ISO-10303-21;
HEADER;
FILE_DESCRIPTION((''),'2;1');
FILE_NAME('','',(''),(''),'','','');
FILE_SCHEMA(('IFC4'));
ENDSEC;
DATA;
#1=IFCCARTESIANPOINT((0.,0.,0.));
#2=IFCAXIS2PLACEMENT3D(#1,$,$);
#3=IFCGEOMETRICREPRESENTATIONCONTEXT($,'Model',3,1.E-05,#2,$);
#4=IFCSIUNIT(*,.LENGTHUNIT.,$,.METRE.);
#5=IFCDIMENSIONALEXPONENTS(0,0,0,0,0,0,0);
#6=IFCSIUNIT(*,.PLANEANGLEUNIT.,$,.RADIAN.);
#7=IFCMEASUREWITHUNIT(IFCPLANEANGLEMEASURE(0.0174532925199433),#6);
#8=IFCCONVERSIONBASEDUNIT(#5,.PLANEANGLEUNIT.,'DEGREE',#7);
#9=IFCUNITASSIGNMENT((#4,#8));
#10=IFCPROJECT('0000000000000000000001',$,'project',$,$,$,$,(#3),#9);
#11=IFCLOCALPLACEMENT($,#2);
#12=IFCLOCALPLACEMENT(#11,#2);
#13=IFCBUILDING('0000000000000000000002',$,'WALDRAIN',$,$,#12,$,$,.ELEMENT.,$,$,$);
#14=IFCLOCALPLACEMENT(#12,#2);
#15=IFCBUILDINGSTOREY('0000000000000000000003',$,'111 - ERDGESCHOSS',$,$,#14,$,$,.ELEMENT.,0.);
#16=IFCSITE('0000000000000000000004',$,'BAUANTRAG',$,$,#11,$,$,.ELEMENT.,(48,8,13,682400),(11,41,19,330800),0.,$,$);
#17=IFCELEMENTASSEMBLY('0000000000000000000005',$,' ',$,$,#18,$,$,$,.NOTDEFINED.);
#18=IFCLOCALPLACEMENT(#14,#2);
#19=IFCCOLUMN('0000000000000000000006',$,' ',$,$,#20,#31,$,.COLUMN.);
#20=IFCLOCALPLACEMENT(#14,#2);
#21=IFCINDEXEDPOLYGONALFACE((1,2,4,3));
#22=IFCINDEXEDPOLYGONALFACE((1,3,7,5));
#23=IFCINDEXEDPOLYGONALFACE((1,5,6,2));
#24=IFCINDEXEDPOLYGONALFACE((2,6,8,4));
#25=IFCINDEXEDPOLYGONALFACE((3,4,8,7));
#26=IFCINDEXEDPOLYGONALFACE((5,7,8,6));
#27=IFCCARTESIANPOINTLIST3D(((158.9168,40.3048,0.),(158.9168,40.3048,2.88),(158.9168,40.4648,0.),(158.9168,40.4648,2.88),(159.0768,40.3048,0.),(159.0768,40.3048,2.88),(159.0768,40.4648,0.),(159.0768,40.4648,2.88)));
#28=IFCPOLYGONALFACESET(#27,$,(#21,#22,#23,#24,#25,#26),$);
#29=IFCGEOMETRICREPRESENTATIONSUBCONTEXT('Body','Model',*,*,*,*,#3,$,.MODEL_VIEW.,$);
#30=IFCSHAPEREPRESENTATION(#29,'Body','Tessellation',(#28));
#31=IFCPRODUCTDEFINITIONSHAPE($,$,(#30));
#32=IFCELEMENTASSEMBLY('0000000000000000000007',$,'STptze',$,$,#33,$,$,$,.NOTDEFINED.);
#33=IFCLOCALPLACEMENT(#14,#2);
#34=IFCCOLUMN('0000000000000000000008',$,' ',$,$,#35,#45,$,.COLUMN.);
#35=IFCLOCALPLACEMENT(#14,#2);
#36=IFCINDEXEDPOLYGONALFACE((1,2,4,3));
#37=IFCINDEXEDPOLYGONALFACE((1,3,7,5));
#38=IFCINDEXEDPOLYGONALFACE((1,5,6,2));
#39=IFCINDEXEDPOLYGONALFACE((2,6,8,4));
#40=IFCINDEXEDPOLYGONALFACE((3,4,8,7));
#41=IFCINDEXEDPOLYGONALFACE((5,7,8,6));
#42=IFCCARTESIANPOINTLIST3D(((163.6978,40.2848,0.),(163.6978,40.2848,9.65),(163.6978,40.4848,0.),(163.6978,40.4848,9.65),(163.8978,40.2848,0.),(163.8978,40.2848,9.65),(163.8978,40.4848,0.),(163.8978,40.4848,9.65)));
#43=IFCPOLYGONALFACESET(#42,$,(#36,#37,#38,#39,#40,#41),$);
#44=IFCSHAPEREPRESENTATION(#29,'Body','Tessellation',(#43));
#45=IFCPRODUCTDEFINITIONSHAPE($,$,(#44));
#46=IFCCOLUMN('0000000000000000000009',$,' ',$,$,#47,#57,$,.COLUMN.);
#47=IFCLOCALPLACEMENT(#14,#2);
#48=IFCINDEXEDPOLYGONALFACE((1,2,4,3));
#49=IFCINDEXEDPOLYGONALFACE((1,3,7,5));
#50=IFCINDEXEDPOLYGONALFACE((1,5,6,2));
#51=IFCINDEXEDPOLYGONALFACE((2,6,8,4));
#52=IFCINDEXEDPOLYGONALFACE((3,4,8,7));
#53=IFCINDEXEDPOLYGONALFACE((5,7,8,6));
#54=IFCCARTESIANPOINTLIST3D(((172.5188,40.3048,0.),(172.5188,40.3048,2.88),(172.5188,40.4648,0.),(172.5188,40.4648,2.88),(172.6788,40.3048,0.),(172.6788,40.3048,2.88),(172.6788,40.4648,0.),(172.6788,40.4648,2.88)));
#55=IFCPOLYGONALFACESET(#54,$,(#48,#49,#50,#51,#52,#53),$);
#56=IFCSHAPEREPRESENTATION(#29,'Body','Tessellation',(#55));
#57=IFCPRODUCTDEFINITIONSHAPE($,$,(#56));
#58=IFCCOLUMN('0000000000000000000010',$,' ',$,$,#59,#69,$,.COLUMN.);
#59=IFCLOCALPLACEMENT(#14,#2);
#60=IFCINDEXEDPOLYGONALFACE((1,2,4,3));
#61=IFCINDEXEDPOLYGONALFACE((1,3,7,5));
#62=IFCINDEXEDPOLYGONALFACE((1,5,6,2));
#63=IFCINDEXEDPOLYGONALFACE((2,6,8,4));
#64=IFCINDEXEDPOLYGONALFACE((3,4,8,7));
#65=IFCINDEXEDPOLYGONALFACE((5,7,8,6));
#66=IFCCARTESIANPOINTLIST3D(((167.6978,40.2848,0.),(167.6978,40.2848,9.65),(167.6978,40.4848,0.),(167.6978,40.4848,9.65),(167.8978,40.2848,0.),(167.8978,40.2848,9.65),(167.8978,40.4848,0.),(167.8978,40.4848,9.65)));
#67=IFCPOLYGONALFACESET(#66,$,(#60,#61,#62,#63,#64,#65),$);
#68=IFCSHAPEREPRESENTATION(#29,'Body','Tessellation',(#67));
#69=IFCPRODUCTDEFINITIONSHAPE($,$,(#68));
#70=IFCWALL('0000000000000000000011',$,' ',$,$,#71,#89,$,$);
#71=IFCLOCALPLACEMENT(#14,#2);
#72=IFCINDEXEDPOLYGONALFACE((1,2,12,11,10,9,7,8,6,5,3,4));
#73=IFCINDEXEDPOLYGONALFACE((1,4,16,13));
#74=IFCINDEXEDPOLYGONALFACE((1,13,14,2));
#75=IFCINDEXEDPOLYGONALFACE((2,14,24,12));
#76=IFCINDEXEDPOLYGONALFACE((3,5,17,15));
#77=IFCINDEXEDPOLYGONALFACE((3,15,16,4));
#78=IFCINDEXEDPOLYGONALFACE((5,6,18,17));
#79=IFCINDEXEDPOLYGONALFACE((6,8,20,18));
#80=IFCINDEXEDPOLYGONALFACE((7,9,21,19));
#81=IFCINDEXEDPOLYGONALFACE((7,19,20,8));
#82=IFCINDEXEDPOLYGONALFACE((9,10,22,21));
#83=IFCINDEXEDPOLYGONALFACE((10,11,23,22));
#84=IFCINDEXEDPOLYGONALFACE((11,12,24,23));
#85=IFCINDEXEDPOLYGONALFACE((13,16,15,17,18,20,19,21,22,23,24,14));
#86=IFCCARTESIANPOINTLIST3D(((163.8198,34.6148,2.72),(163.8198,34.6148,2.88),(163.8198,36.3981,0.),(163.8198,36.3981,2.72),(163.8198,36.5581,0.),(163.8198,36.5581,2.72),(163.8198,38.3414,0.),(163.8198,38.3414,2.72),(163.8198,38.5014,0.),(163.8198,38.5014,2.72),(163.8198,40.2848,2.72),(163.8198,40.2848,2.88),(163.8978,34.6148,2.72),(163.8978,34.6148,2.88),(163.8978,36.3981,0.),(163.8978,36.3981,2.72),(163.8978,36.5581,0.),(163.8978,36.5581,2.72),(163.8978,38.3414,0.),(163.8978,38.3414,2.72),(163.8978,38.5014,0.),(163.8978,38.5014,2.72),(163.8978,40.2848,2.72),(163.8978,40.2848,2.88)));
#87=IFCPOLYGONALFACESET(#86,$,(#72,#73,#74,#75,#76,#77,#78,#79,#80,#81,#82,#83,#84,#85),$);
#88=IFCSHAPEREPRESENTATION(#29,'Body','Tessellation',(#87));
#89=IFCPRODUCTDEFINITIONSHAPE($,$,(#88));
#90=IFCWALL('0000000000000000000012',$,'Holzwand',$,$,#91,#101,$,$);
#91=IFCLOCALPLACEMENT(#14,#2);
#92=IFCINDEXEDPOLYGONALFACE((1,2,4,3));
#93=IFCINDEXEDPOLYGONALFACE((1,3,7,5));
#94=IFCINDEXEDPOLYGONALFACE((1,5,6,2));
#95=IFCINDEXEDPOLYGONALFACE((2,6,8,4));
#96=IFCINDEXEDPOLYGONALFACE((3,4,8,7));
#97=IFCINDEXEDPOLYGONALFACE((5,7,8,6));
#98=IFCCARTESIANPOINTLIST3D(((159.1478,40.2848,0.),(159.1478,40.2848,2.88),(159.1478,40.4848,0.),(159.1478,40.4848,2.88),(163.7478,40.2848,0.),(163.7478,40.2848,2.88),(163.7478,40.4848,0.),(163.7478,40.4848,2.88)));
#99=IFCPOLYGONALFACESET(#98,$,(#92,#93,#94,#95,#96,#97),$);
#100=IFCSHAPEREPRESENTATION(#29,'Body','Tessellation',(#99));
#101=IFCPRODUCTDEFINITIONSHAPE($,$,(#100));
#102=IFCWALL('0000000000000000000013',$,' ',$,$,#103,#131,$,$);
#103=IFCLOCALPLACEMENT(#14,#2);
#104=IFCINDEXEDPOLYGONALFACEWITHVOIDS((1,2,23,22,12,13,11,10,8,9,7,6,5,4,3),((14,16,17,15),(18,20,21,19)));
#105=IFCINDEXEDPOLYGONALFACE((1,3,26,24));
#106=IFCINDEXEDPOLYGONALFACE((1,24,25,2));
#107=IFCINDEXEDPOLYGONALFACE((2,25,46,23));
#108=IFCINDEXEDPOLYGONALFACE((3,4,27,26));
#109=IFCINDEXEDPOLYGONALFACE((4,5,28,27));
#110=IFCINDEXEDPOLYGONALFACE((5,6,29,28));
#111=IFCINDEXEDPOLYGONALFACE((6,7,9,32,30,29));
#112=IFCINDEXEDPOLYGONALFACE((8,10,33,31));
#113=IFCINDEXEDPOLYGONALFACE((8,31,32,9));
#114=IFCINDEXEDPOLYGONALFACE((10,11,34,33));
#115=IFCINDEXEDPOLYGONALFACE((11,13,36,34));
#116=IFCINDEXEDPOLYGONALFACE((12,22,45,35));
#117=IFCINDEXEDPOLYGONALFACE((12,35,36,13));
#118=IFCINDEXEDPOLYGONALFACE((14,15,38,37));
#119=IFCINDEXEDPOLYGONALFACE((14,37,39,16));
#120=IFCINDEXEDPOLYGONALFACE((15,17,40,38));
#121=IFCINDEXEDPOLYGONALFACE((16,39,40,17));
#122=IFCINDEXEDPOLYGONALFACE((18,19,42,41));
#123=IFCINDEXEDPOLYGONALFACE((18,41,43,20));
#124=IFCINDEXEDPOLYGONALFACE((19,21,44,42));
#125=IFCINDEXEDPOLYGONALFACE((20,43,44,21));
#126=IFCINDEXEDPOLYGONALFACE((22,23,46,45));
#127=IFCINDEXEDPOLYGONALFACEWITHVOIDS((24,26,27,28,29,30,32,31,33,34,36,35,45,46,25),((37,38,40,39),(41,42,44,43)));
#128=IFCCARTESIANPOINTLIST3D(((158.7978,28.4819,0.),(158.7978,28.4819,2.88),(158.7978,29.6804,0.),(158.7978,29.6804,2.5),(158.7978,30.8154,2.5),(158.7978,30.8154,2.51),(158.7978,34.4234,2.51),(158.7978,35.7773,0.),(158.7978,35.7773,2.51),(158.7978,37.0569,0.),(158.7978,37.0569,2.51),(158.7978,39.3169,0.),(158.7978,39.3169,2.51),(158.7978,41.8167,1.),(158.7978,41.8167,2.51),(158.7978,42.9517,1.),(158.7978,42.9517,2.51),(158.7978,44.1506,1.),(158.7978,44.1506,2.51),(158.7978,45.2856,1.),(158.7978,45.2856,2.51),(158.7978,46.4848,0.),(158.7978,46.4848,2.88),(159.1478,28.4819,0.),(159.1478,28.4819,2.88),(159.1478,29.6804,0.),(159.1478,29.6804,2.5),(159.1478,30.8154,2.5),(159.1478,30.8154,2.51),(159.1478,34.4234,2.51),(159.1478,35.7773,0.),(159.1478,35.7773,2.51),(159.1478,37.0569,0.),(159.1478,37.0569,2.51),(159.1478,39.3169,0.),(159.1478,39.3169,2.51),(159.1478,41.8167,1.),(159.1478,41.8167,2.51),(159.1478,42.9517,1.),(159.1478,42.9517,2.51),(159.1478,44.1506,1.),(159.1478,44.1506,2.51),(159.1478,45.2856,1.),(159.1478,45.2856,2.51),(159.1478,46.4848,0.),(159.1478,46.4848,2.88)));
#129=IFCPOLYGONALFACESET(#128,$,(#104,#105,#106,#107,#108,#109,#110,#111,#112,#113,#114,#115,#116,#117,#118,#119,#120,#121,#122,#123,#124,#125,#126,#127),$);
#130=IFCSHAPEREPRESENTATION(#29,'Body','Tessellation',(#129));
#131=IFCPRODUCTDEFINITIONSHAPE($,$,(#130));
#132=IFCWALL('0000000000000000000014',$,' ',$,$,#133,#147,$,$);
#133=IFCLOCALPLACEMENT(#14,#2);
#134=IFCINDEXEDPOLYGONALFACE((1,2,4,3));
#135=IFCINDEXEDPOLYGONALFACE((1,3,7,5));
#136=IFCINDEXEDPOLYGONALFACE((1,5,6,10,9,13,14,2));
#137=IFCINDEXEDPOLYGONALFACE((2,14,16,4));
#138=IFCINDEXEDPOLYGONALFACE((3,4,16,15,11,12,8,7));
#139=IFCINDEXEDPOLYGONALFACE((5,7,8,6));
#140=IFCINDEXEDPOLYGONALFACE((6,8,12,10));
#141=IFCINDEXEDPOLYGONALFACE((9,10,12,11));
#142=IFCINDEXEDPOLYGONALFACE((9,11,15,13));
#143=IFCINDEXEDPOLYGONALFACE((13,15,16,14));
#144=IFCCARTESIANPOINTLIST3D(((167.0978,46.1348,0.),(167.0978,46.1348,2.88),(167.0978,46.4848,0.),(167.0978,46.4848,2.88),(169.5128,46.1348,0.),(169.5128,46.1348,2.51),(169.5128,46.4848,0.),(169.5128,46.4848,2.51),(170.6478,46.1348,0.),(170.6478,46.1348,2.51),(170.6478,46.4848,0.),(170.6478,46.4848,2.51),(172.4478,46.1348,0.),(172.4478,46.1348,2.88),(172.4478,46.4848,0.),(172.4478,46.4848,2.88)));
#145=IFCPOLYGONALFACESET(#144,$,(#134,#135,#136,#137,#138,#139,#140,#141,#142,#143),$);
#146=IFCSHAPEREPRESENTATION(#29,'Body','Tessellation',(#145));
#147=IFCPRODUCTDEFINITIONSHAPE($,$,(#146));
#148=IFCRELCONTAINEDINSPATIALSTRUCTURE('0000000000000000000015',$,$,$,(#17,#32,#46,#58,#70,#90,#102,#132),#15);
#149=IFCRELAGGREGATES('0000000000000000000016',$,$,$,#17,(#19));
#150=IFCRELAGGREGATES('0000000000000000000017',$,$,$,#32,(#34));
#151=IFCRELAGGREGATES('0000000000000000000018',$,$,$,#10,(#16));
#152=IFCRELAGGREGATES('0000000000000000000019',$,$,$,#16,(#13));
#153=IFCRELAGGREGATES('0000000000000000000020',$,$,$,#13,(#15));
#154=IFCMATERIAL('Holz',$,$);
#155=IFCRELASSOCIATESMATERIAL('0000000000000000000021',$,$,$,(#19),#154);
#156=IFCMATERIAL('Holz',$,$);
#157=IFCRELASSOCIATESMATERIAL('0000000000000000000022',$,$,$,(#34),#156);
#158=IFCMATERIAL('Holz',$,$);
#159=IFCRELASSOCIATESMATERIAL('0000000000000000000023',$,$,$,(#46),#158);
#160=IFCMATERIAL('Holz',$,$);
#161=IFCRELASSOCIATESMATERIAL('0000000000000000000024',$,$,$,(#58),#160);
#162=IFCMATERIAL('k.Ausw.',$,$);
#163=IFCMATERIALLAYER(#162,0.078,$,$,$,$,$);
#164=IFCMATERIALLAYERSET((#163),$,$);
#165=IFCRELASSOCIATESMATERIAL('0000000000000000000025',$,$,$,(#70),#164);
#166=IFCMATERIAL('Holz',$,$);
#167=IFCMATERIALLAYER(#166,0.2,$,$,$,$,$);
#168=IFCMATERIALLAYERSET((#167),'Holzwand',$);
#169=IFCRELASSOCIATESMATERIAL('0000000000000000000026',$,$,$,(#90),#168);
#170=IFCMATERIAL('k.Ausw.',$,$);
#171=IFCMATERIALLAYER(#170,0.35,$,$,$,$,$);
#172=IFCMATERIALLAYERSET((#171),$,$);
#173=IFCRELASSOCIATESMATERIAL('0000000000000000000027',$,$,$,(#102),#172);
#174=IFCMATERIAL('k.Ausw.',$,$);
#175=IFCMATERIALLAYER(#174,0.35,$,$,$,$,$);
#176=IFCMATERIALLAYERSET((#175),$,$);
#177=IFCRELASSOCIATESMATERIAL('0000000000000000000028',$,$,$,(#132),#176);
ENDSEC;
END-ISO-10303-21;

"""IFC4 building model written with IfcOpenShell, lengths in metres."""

from ifc_helpers import new_model, entity, si_unit, converted_unit, frame, frame_2d, origin, origin_with_axes, place, context, subcontext, project, spatial, polyline, rectangle, outline, extrude, material, layer, layer_set, layer_usage, element, aggregate, save


model = new_model("IFC4")

# Units and contexts
model_context = context("Model", 3, precision=1e-05, world=origin())
body_context = subcontext(model_context, "Body", "Model", "MODEL_VIEW")
ifc_project = project(units=[si_unit("LENGTHUNIT", "METRE"), converted_unit("PLANEANGLEUNIT", "DEGREE", entity("IfcPlaneAngleMeasure", 0.0174532925199433), si_unit("PLANEANGLEUNIT", "RADIAN"), dimensions=[0, 0, 0, 0, 0, 0, 0])], contexts=[model_context])

# Site, building, storey
site_placement = place(None, origin())
site = spatial("IfcSite", under=ifc_project, at=site_placement, Name="BAUANTRAG", CompositionType="ELEMENT", RefLatitude=(48, 8, 13, 682400), RefLongitude=(11, 41, 19, 330800), RefElevation=0.0)
building_placement = place(site_placement, origin())
building = spatial("IfcBuilding", under=site, at=building_placement, Name="WALDRAIN", CompositionType="ELEMENT")
storey_placement = place(building_placement, origin())
storey = spatial("IfcBuildingStorey", under=building, at=storey_placement, Name="111 - ERDGESCHOSS", CompositionType="ELEMENT", Elevation=0.0)

# Element assemblies, columns
assembly_1_placement = place(storey_placement, origin())
assembly_1 = element("IfcElementAssembly", 1, at=assembly_1_placement, inside=storey, Name=" ", PredefinedType="NOTDEFINED")
ifc_material_1 = material(Name="Holz")
column_1_placement = place(assembly_1_placement, frame((158.9168, 40.3048, 0.0)))
column_1 = element("IfcColumn", 2, at=column_1_placement, material=ifc_material_1, Name=" ", PredefinedType="COLUMN", context=body_context, shape_type="SweptSolid", body=[
    extrude(rectangle(XDim=0.16, YDim=0.16, at=frame_2d((0.08, 0.08), x_axis=(1.0, 0.0))), origin_with_axes(), (0.0, 0.0, 1.0), 2.88),
])
aggregate(assembly_1, [column_1])
assembly_2_placement = place(storey_placement, origin())
assembly_2 = element("IfcElementAssembly", 3, at=assembly_2_placement, inside=storey, Name="STptze", PredefinedType="NOTDEFINED")
ifc_material_2 = material(Name="Holz")
column_2_placement = place(assembly_2_placement, frame((163.6978, 40.2848, 0.0)))
column_2 = element("IfcColumn", 4, at=column_2_placement, material=ifc_material_2, Name=" ", PredefinedType="COLUMN", context=body_context, shape_type="SweptSolid", body=[
    extrude(rectangle(XDim=0.2, YDim=0.2, at=frame_2d((0.1, 0.1), x_axis=(1.0, 0.0))), origin_with_axes(), (0.0, 0.0, 1.0), 9.65),
])
aggregate(assembly_2, [column_2])

# Columns
ifc_material_3 = material(Name="Holz")
column_3_placement = place(storey_placement, frame((172.5188, 40.3048, 0.0)))
element("IfcColumn", 5, at=column_3_placement, inside=storey, material=ifc_material_3, Name=" ", PredefinedType="COLUMN", context=body_context, shape_type="SweptSolid", body=[
    extrude(rectangle(XDim=0.16, YDim=0.16, at=frame_2d((0.08, 0.08), x_axis=(1.0, 0.0))), origin_with_axes(), (0.0, 0.0, 1.0), 2.88),
])
ifc_material_4 = material(Name="Holz")
column_4_placement = place(storey_placement, frame((167.6978, 40.2848, 0.0)))
element("IfcColumn", 6, at=column_4_placement, inside=storey, material=ifc_material_4, Name=" ", PredefinedType="COLUMN", context=body_context, shape_type="SweptSolid", body=[
    extrude(rectangle(XDim=0.2, YDim=0.2, at=frame_2d((0.1, 0.1), x_axis=(1.0, 0.0))), origin_with_axes(), (0.0, 0.0, 1.0), 9.65),
])

# Wall, openings
ifc_material_5 = material(Name="k.Ausw.")
ifc_layer_1 = layer(ifc_material_5, 0.078)
ifc_layer_set_1 = layer_set([ifc_layer_1])
ifc_layer_usage_1 = layer_usage(ifc_layer_set_1, "AXIS2", "POSITIVE", 0.0)
wall_1_placement = place(storey_placement, frame((163.8198, 40.2848, 0.0), z_axis=(0.0, 0.0, 1.0), x_axis=(0.0, -1.0, 0.0)))
wall_1 = element("IfcWall", 7, at=wall_1_placement, inside=storey, material=ifc_layer_usage_1, Name=" ", context=body_context, shape_type="SweptSolid", body=[
    extrude(rectangle(XDim=5.67, YDim=0.078, at=frame_2d((2.835, 0.039), x_axis=(1.0, 0.0))), origin_with_axes(), (0.0, 0.0, 1.0), 2.88),
])
opening_1_placement = place(wall_1_placement, frame((1.9434, 0.0, 0.0), z_axis=(0.0, 1.0, 0.0), x_axis=(0.0, 0.0, 1.0)))
element("IfcOpeningElement", 8, at=opening_1_placement, cuts=wall_1, ObjectType="Opening", context=body_context, shape_type="SweptSolid", body=[
    extrude(outline(polyline([(0.0, 1.7833), (2.72, 1.7833), (2.72, 0.0), (0.0, 0.0), (0.0, 1.7833)])), origin_with_axes(), (0.0, 0.0, 1.0), 0.078),
])
opening_2_placement = place(wall_1_placement, frame((0.0, 0.0, 0.0), z_axis=(0.0, 1.0, 0.0), x_axis=(0.0, 0.0, 1.0)))
element("IfcOpeningElement", 9, at=opening_2_placement, cuts=wall_1, ObjectType="Opening", context=body_context, shape_type="SweptSolid", body=[
    extrude(outline(polyline([(0.0, 1.7834), (2.72, 1.7834), (2.72, 0.0), (0.0, 0.0), (0.0, 1.7834)])), origin_with_axes(), (0.0, 0.0, 1.0), 0.078),
])
opening_3_placement = place(wall_1_placement, frame((3.8867, 0.0, 0.0), z_axis=(0.0, 1.0, 0.0), x_axis=(0.0, 0.0, 1.0)))
element("IfcOpeningElement", 10, at=opening_3_placement, cuts=wall_1, ObjectType="Opening", context=body_context, shape_type="SweptSolid", body=[
    extrude(outline(polyline([(0.0, 1.7833), (2.72, 1.7833), (2.72, 0.0), (0.0, 0.0), (0.0, 1.7833)])), origin_with_axes(), (0.0, 0.0, 1.0), 0.078),
])

# Wall
ifc_material_6 = material(Name="Holz")
ifc_layer_2 = layer(ifc_material_6, 0.2)
ifc_layer_set_2 = layer_set([ifc_layer_2], Name="Holzwand")
ifc_layer_usage_2 = layer_usage(ifc_layer_set_2, "AXIS2", "POSITIVE", 0.0)
wall_2_placement = place(storey_placement, frame((163.7478, 40.4848, 0.0), z_axis=(0.0, 0.0, 1.0), x_axis=(-1.0, 0.0, 0.0)))
element("IfcWall", 11, at=wall_2_placement, inside=storey, material=ifc_layer_usage_2, Name="Holzwand", context=body_context, shape_type="SweptSolid", body=[
    extrude(rectangle(XDim=4.6, YDim=0.2, at=frame_2d((2.3, 0.1), x_axis=(1.0, 0.0))), origin_with_axes(), (0.0, 0.0, 1.0), 2.88),
])

# Wall, openings
ifc_material_7 = material(Name="k.Ausw.")
ifc_layer_3 = layer(ifc_material_7, 0.35)
ifc_layer_set_3 = layer_set([ifc_layer_3])
ifc_layer_usage_3 = layer_usage(ifc_layer_set_3, "AXIS2", "POSITIVE", 0.0)
wall_3_placement = place(storey_placement, frame((158.7978, 46.4848, 0.0), z_axis=(0.0, 0.0, 1.0), x_axis=(0.0, -1.0, 0.0)))
wall_3 = element("IfcWall", 12, at=wall_3_placement, inside=storey, material=ifc_layer_usage_3, Name=" ", context=body_context, shape_type="SweptSolid", body=[
    extrude(rectangle(XDim=18.0029, YDim=0.35, at=frame_2d((9.0014, 0.175), x_axis=(1.0, 0.0))), origin_with_axes(), (0.0, 0.0, 1.0), 2.88),
])
opening_4_placement = place(wall_3_placement, frame((1.1992, 0.0, 1.0), z_axis=(0.0, 1.0, 0.0), x_axis=(0.0, 0.0, 1.0)))
element("IfcOpeningElement", 13, at=opening_4_placement, cuts=wall_3, ObjectType="Opening", context=body_context, shape_type="SweptSolid", body=[
    extrude(outline(polyline([(0.0, 1.135), (1.51, 1.135), (1.51, 0.0), (0.0, 0.0), (0.0, 1.135)])), origin_with_axes(), (0.0, 0.0, 1.0), 0.35),
])
opening_5_placement = place(wall_3_placement, frame((3.5331, 0.0, 1.0), z_axis=(0.0, 1.0, 0.0), x_axis=(0.0, 0.0, 1.0)))
element("IfcOpeningElement", 14, at=opening_5_placement, cuts=wall_3, ObjectType="Opening", context=body_context, shape_type="SweptSolid", body=[
    extrude(outline(polyline([(0.0, 1.135), (1.51, 1.135), (1.51, 0.0), (0.0, 0.0), (0.0, 1.135)])), origin_with_axes(), (0.0, 0.0, 1.0), 0.35),
])
opening_6_placement = place(wall_3_placement, frame((7.1679, 0.0, 0.0), z_axis=(0.0, 1.0, 0.0), x_axis=(0.0, 0.0, 1.0)))
element("IfcOpeningElement", 15, at=opening_6_placement, cuts=wall_3, ObjectType="Opening", context=body_context, shape_type="SweptSolid", body=[
    extrude(outline(polyline([(0.0, 2.26), (2.51, 2.26), (2.51, 0.0), (0.0, 0.0), (0.0, 2.26)])), origin_with_axes(), (0.0, 0.0, 1.0), 0.35),
])
opening_7_placement = place(wall_3_placement, frame((10.7075, 0.0, 0.0), z_axis=(0.0, 1.0, 0.0), x_axis=(0.0, 0.0, 1.0)))
element("IfcOpeningElement", 16, at=opening_7_placement, cuts=wall_3, ObjectType="Opening", context=body_context, shape_type="SweptSolid", body=[
    extrude(outline(polyline([(0.0, 1.3539), (2.51, 1.3539), (2.51, 0.0), (0.0, 0.0), (0.0, 1.3539)])), origin_with_axes(), (0.0, 0.0, 1.0), 0.35),
])
opening_8_placement = place(wall_3_placement, frame((15.6694, 0.0, 0.0), z_axis=(0.0, 1.0, 0.0), x_axis=(0.0, 0.0, 1.0)))
element("IfcOpeningElement", 17, at=opening_8_placement, cuts=wall_3, ObjectType="Opening", context=body_context, shape_type="SweptSolid", body=[
    extrude(outline(polyline([(0.0, 1.135), (2.5, 1.135), (2.5, 0.0), (0.0, 0.0), (0.0, 1.135)])), origin_with_axes(), (0.0, 0.0, 1.0), 0.35),
])
opening_9_placement = place(wall_3_placement, frame((12.0614, 0.0, 0.0), z_axis=(0.0, 1.0, 0.0), x_axis=(0.0, 0.0, 1.0)))
element("IfcOpeningElement", 18, at=opening_9_placement, cuts=wall_3, ObjectType="Opening", context=body_context, shape_type="SweptSolid", body=[
    extrude(outline(polyline([(0.0, 3.608), (2.51, 3.608), (2.51, 0.0), (0.0, 0.0), (0.0, 3.608)])), origin_with_axes(), (0.0, 0.0, 1.0), 0.35),
])

# Wall, opening
ifc_material_8 = material(Name="k.Ausw.")
ifc_layer_4 = layer(ifc_material_8, 0.35)
ifc_layer_set_4 = layer_set([ifc_layer_4])
ifc_layer_usage_4 = layer_usage(ifc_layer_set_4, "AXIS2", "POSITIVE", 0.0)
wall_4_placement = place(storey_placement, frame((172.4478, 46.4848, 0.0), z_axis=(0.0, 0.0, 1.0), x_axis=(-1.0, 0.0, 0.0)))
wall_4 = element("IfcWall", 19, at=wall_4_placement, inside=storey, material=ifc_layer_usage_4, Name=" ", context=body_context, shape_type="SweptSolid", body=[
    extrude(rectangle(XDim=5.35, YDim=0.35, at=frame_2d((2.675, 0.175), x_axis=(1.0, 0.0))), origin_with_axes(), (0.0, 0.0, 1.0), 2.88),
])
opening_10_placement = place(wall_4_placement, frame((2.935, 0.35, 0.0), z_axis=(0.0, -1.0, 0.0), x_axis=(0.0, 0.0, 1.0)))
element("IfcOpeningElement", 20, at=opening_10_placement, cuts=wall_4, ObjectType="Opening", context=body_context, shape_type="SweptSolid", body=[
    extrude(outline(polyline([(0.0, 1.135), (2.51, 1.135), (2.51, 0.0), (0.0, 0.0), (0.0, 1.135)])), origin_with_axes(), (0.0, 0.0, 1.0), 0.35),
])

save(model, "model.ifc")
